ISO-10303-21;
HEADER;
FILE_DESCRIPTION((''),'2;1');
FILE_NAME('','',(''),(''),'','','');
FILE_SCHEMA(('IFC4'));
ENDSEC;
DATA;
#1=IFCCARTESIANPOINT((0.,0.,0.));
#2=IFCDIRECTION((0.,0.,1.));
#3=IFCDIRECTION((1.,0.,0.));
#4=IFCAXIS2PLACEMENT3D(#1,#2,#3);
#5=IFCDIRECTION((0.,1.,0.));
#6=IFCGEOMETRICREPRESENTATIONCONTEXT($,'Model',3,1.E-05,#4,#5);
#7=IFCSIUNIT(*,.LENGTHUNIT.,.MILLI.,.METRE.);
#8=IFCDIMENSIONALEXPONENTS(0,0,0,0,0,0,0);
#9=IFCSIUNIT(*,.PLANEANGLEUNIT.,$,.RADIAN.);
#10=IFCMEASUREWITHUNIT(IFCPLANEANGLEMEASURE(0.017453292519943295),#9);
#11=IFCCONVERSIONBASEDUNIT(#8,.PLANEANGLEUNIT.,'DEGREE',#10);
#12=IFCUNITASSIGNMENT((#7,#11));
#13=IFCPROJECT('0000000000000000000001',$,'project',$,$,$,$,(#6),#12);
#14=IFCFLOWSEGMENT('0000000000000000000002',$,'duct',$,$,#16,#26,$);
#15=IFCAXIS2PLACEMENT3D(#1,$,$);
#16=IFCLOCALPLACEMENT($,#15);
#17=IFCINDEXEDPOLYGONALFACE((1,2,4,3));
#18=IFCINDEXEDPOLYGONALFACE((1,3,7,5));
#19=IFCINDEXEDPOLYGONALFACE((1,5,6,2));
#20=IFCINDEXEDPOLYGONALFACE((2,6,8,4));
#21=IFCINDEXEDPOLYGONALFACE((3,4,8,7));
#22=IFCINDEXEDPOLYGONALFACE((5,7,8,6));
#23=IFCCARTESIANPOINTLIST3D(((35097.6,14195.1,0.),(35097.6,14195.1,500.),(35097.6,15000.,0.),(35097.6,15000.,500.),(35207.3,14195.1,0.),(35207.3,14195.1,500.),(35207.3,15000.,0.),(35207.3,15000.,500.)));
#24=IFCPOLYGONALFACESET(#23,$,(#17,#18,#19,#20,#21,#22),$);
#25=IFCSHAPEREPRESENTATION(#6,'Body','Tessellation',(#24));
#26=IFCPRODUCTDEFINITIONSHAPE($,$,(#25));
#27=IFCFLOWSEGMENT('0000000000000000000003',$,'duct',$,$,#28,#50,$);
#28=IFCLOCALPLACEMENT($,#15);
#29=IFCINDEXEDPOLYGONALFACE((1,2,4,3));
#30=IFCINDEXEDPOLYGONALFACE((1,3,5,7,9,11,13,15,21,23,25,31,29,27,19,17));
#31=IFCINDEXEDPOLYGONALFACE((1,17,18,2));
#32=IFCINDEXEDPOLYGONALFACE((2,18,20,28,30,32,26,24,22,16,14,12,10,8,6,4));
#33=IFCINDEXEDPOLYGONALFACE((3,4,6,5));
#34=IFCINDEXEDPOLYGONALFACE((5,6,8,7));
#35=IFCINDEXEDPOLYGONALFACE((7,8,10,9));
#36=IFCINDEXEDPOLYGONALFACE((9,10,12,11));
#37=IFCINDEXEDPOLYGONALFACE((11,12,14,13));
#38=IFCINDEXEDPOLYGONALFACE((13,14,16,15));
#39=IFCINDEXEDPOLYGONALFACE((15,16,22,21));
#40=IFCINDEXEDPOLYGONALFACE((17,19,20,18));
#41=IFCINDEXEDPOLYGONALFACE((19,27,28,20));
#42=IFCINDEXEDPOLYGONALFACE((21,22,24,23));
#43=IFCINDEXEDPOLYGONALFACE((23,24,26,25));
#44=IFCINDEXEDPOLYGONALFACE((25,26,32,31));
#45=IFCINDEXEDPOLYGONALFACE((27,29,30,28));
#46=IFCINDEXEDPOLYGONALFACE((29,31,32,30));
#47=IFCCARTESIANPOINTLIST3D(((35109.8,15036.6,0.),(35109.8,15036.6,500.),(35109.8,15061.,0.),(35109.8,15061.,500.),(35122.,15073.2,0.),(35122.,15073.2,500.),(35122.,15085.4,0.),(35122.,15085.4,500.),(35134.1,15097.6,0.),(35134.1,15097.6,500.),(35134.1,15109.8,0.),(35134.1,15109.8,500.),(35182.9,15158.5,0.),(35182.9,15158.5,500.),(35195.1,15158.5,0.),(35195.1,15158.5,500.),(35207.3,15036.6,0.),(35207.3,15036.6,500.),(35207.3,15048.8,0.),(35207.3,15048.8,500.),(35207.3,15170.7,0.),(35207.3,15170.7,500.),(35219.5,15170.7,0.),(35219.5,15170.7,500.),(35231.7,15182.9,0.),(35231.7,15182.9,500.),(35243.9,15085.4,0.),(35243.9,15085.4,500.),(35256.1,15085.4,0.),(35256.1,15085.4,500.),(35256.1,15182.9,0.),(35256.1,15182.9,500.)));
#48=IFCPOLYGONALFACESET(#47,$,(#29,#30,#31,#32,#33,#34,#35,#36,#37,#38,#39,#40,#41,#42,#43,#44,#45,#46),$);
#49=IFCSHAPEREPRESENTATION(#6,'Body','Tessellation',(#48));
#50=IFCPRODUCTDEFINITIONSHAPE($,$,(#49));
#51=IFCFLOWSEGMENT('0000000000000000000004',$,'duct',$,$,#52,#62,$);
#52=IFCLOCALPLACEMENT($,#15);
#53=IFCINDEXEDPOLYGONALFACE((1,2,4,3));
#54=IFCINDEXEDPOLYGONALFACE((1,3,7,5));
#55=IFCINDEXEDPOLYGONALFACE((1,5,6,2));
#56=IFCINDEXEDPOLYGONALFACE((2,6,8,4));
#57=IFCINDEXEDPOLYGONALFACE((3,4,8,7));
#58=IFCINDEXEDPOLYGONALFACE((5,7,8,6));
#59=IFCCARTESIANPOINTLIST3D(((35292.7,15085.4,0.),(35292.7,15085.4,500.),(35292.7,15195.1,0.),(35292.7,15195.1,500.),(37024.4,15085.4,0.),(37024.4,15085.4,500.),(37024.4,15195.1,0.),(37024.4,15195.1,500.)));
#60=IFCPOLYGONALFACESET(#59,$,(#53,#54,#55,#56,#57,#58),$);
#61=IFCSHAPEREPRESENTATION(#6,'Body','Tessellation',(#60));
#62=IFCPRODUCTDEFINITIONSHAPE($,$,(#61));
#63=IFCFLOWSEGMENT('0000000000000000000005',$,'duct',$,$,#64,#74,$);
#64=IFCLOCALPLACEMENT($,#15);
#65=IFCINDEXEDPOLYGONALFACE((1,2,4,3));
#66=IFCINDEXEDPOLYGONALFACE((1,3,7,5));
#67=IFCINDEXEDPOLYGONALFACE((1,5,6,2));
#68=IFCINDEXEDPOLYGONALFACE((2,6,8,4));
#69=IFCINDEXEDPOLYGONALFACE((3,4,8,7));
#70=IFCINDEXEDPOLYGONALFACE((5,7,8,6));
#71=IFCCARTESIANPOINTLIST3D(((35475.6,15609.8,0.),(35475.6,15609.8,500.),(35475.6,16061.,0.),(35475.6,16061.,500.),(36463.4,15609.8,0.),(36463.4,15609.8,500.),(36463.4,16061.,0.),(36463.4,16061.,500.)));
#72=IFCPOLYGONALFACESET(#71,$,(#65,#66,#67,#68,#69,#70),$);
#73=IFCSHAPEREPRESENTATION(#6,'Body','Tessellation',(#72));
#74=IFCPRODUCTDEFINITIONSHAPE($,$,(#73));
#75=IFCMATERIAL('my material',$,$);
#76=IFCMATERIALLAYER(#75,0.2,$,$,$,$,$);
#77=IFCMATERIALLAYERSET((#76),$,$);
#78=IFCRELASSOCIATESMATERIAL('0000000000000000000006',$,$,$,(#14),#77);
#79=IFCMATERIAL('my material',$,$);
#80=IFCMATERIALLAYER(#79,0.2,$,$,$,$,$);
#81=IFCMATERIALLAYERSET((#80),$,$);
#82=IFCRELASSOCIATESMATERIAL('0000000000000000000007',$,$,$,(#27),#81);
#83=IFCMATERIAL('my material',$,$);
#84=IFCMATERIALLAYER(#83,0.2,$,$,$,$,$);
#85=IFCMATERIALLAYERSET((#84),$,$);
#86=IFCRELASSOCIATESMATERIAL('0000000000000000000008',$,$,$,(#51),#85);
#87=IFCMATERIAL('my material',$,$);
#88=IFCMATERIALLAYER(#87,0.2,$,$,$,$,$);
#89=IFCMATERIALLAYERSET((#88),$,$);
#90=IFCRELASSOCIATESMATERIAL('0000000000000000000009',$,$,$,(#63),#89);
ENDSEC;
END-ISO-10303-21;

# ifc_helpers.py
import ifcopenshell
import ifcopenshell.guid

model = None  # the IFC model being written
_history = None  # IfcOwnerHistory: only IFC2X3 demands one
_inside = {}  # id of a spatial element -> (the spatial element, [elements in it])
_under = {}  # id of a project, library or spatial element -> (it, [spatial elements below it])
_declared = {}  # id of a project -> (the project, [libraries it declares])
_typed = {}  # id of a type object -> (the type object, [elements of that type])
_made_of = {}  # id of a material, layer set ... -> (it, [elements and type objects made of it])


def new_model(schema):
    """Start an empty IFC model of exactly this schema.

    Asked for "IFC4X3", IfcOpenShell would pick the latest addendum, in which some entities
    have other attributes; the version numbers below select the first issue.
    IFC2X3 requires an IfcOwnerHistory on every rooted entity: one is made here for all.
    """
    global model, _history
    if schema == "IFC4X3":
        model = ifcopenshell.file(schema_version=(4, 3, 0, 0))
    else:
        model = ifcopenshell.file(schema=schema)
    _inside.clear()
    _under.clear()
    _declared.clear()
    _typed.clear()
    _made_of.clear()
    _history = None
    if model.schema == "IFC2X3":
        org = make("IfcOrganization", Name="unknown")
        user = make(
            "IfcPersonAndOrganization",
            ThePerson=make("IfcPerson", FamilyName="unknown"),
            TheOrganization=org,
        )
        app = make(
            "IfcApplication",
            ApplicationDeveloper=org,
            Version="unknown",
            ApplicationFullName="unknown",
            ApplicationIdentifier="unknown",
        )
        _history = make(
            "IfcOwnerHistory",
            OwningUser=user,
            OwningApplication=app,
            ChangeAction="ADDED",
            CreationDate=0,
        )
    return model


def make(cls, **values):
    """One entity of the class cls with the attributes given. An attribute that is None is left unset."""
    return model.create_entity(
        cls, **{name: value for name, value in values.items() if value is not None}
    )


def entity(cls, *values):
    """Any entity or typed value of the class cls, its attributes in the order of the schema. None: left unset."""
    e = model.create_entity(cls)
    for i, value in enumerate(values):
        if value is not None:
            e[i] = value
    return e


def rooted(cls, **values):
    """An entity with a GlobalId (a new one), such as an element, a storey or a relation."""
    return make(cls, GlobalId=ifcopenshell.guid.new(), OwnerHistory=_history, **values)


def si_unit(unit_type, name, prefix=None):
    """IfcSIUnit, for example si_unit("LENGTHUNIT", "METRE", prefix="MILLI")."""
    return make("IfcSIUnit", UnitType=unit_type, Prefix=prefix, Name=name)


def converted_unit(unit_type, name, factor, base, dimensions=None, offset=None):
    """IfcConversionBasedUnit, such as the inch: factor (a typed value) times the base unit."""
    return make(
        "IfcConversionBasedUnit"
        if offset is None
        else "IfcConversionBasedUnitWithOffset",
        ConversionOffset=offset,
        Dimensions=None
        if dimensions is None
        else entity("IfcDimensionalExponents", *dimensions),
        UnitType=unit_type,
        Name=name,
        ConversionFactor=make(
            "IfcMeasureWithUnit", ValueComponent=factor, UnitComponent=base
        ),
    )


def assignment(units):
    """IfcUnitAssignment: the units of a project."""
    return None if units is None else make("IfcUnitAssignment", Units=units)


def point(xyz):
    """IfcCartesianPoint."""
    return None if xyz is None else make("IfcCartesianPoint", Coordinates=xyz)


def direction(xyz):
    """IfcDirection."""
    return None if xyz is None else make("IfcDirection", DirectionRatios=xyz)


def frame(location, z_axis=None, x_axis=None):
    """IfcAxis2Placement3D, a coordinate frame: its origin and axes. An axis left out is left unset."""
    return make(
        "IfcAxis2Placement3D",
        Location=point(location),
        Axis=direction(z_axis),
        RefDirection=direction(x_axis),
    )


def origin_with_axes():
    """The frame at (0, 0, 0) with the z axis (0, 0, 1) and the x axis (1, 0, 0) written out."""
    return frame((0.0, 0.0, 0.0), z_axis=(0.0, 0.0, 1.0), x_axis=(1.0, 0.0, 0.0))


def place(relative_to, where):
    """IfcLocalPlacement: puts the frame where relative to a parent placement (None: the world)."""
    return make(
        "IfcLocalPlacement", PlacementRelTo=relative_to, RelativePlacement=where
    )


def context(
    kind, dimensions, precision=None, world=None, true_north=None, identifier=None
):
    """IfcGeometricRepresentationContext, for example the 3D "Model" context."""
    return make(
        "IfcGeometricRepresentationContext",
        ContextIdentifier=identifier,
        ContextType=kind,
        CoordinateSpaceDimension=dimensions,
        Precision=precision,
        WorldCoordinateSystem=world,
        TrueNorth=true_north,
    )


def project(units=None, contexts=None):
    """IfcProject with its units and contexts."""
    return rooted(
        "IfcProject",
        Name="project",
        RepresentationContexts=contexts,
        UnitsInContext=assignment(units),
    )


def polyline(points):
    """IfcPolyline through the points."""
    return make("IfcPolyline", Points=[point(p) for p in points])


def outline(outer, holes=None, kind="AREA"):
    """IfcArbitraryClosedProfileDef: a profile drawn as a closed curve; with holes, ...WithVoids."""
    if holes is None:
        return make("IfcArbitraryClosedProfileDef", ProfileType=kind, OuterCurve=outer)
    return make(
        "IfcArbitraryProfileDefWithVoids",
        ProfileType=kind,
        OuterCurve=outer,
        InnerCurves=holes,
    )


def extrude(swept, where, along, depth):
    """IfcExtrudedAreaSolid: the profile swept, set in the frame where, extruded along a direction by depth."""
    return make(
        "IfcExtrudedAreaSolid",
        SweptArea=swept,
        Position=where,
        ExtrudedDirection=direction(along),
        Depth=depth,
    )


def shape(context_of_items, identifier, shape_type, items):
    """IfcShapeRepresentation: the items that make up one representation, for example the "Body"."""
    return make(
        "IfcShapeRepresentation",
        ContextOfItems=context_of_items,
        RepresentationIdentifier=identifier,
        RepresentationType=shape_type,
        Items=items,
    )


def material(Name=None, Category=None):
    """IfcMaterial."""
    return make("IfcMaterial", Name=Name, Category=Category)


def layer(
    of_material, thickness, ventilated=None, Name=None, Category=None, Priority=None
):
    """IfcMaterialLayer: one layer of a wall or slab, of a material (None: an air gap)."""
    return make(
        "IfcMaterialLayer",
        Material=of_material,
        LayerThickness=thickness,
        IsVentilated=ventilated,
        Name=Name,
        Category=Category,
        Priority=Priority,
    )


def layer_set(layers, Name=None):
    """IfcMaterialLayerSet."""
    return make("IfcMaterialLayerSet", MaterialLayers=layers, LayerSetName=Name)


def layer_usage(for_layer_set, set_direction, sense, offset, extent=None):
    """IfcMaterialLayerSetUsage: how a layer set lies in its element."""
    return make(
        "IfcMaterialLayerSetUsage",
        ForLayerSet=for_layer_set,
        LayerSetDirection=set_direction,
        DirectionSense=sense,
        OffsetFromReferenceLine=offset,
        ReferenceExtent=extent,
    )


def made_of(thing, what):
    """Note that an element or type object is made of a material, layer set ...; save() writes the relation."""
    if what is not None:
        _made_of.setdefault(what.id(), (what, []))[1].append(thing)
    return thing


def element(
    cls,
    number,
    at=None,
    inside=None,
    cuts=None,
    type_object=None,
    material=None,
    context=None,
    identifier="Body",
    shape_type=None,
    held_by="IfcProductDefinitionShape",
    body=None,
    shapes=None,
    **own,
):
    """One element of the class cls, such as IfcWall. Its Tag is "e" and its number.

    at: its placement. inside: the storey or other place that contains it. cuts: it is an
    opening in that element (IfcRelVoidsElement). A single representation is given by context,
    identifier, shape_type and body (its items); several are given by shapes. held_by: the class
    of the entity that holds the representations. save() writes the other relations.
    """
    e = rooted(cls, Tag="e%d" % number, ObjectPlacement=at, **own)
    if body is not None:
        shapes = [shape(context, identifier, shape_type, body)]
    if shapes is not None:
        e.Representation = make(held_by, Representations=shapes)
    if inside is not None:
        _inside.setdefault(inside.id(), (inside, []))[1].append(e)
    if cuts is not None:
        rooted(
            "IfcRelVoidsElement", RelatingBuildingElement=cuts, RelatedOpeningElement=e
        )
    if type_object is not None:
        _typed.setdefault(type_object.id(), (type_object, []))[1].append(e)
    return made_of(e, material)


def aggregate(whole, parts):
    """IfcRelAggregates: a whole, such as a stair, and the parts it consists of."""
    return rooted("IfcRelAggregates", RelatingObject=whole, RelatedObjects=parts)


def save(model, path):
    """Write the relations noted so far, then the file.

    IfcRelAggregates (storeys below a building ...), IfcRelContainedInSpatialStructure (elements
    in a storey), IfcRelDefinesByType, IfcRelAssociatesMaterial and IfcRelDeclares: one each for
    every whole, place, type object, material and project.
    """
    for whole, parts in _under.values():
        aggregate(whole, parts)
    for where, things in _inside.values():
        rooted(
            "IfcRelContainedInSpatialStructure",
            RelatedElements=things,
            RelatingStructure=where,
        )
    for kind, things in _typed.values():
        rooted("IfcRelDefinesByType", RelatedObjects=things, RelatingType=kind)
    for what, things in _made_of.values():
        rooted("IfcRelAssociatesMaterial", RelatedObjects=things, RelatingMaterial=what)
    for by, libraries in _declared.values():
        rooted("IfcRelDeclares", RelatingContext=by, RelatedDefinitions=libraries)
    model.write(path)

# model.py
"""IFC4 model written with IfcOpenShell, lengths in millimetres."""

from ifc_helpers import new_model, entity, si_unit, converted_unit, direction, origin_with_axes, place, context, project, polyline, outline, extrude, material, layer, layer_set, layer_usage, element, save


model = new_model("IFC4")

# Units and contexts
model_context = context("Model", 3, precision=1e-05, world=origin_with_axes(), true_north=direction((0.0, 1.0, 0.0)))
ifc_project = project(units=[si_unit("LENGTHUNIT", "METRE", prefix="MILLI"), converted_unit("PLANEANGLEUNIT", "DEGREE", entity("IfcPlaneAngleMeasure", 0.017453292519943295), si_unit("PLANEANGLEUNIT", "RADIAN"), dimensions=[0, 0, 0, 0, 0, 0, 0])], contexts=[model_context])

# Flow segments
ifc_material_1 = material(Name="my material")
ifc_layer_1 = layer(ifc_material_1, 0.2)
ifc_layer_set_1 = layer_set([ifc_layer_1])
ifc_layer_usage_1 = layer_usage(ifc_layer_set_1, "AXIS2", "POSITIVE", -0.1)
flow_segment_1_placement = place(None, origin_with_axes())
element("IfcFlowSegment", 1, at=flow_segment_1_placement, material=ifc_layer_usage_1, Name="duct", context=model_context, shape_type="SweptSolid", body=[
    extrude(outline(polyline([(35097.6, 14195.1), (35207.3, 14195.1), (35207.3, 15000.0), (35097.6, 15000.0), (35097.6, 14195.1)])), origin_with_axes(), (0.0, 0.0, 1.0), 500.0),
])
ifc_material_2 = material(Name="my material")
ifc_layer_2 = layer(ifc_material_2, 0.2)
ifc_layer_set_2 = layer_set([ifc_layer_2])
ifc_layer_usage_2 = layer_usage(ifc_layer_set_2, "AXIS2", "POSITIVE", -0.1)
flow_segment_2_placement = place(None, origin_with_axes())
element("IfcFlowSegment", 2, at=flow_segment_2_placement, material=ifc_layer_usage_2, Name="duct", context=model_context, shape_type="SweptSolid", body=[
    extrude(outline(polyline([(35109.8, 15036.6), (35207.3, 15036.6), (35207.3, 15048.8), (35243.9, 15085.4), (35256.1, 15085.4), (35256.1, 15182.9), (35231.7, 15182.9), (35219.5, 15170.7), (35207.3, 15170.7), (35195.1, 15158.5), (35182.9, 15158.5), (35134.1, 15109.8), (35134.1, 15097.6), (35122.0, 15085.4), (35122.0, 15073.2), (35109.8, 15061.0), (35109.8, 15036.6)])), origin_with_axes(), (0.0, 0.0, 1.0), 500.0),
])
ifc_material_3 = material(Name="my material")
ifc_layer_3 = layer(ifc_material_3, 0.2)
ifc_layer_set_3 = layer_set([ifc_layer_3])
ifc_layer_usage_3 = layer_usage(ifc_layer_set_3, "AXIS2", "POSITIVE", -0.1)
flow_segment_3_placement = place(None, origin_with_axes())
element("IfcFlowSegment", 3, at=flow_segment_3_placement, material=ifc_layer_usage_3, Name="duct", context=model_context, shape_type="SweptSolid", body=[
    extrude(outline(polyline([(35292.7, 15085.4), (37024.4, 15085.4), (37024.4, 15195.1), (35292.7, 15195.1), (35292.7, 15085.4)])), origin_with_axes(), (0.0, 0.0, 1.0), 500.0),
])
ifc_material_4 = material(Name="my material")
ifc_layer_4 = layer(ifc_material_4, 0.2)
ifc_layer_set_4 = layer_set([ifc_layer_4])
ifc_layer_usage_4 = layer_usage(ifc_layer_set_4, "AXIS2", "POSITIVE", -0.1)
flow_segment_4_placement = place(None, origin_with_axes())
element("IfcFlowSegment", 4, at=flow_segment_4_placement, material=ifc_layer_usage_4, Name="duct", context=model_context, shape_type="SweptSolid", body=[
    extrude(outline(polyline([(35475.6, 15609.8), (36463.4, 15609.8), (36463.4, 16061.0), (35475.6, 16061.0), (35475.6, 15609.8)])), origin_with_axes(), (0.0, 0.0, 1.0), 500.0),
])

save(model, "model.ifc")
